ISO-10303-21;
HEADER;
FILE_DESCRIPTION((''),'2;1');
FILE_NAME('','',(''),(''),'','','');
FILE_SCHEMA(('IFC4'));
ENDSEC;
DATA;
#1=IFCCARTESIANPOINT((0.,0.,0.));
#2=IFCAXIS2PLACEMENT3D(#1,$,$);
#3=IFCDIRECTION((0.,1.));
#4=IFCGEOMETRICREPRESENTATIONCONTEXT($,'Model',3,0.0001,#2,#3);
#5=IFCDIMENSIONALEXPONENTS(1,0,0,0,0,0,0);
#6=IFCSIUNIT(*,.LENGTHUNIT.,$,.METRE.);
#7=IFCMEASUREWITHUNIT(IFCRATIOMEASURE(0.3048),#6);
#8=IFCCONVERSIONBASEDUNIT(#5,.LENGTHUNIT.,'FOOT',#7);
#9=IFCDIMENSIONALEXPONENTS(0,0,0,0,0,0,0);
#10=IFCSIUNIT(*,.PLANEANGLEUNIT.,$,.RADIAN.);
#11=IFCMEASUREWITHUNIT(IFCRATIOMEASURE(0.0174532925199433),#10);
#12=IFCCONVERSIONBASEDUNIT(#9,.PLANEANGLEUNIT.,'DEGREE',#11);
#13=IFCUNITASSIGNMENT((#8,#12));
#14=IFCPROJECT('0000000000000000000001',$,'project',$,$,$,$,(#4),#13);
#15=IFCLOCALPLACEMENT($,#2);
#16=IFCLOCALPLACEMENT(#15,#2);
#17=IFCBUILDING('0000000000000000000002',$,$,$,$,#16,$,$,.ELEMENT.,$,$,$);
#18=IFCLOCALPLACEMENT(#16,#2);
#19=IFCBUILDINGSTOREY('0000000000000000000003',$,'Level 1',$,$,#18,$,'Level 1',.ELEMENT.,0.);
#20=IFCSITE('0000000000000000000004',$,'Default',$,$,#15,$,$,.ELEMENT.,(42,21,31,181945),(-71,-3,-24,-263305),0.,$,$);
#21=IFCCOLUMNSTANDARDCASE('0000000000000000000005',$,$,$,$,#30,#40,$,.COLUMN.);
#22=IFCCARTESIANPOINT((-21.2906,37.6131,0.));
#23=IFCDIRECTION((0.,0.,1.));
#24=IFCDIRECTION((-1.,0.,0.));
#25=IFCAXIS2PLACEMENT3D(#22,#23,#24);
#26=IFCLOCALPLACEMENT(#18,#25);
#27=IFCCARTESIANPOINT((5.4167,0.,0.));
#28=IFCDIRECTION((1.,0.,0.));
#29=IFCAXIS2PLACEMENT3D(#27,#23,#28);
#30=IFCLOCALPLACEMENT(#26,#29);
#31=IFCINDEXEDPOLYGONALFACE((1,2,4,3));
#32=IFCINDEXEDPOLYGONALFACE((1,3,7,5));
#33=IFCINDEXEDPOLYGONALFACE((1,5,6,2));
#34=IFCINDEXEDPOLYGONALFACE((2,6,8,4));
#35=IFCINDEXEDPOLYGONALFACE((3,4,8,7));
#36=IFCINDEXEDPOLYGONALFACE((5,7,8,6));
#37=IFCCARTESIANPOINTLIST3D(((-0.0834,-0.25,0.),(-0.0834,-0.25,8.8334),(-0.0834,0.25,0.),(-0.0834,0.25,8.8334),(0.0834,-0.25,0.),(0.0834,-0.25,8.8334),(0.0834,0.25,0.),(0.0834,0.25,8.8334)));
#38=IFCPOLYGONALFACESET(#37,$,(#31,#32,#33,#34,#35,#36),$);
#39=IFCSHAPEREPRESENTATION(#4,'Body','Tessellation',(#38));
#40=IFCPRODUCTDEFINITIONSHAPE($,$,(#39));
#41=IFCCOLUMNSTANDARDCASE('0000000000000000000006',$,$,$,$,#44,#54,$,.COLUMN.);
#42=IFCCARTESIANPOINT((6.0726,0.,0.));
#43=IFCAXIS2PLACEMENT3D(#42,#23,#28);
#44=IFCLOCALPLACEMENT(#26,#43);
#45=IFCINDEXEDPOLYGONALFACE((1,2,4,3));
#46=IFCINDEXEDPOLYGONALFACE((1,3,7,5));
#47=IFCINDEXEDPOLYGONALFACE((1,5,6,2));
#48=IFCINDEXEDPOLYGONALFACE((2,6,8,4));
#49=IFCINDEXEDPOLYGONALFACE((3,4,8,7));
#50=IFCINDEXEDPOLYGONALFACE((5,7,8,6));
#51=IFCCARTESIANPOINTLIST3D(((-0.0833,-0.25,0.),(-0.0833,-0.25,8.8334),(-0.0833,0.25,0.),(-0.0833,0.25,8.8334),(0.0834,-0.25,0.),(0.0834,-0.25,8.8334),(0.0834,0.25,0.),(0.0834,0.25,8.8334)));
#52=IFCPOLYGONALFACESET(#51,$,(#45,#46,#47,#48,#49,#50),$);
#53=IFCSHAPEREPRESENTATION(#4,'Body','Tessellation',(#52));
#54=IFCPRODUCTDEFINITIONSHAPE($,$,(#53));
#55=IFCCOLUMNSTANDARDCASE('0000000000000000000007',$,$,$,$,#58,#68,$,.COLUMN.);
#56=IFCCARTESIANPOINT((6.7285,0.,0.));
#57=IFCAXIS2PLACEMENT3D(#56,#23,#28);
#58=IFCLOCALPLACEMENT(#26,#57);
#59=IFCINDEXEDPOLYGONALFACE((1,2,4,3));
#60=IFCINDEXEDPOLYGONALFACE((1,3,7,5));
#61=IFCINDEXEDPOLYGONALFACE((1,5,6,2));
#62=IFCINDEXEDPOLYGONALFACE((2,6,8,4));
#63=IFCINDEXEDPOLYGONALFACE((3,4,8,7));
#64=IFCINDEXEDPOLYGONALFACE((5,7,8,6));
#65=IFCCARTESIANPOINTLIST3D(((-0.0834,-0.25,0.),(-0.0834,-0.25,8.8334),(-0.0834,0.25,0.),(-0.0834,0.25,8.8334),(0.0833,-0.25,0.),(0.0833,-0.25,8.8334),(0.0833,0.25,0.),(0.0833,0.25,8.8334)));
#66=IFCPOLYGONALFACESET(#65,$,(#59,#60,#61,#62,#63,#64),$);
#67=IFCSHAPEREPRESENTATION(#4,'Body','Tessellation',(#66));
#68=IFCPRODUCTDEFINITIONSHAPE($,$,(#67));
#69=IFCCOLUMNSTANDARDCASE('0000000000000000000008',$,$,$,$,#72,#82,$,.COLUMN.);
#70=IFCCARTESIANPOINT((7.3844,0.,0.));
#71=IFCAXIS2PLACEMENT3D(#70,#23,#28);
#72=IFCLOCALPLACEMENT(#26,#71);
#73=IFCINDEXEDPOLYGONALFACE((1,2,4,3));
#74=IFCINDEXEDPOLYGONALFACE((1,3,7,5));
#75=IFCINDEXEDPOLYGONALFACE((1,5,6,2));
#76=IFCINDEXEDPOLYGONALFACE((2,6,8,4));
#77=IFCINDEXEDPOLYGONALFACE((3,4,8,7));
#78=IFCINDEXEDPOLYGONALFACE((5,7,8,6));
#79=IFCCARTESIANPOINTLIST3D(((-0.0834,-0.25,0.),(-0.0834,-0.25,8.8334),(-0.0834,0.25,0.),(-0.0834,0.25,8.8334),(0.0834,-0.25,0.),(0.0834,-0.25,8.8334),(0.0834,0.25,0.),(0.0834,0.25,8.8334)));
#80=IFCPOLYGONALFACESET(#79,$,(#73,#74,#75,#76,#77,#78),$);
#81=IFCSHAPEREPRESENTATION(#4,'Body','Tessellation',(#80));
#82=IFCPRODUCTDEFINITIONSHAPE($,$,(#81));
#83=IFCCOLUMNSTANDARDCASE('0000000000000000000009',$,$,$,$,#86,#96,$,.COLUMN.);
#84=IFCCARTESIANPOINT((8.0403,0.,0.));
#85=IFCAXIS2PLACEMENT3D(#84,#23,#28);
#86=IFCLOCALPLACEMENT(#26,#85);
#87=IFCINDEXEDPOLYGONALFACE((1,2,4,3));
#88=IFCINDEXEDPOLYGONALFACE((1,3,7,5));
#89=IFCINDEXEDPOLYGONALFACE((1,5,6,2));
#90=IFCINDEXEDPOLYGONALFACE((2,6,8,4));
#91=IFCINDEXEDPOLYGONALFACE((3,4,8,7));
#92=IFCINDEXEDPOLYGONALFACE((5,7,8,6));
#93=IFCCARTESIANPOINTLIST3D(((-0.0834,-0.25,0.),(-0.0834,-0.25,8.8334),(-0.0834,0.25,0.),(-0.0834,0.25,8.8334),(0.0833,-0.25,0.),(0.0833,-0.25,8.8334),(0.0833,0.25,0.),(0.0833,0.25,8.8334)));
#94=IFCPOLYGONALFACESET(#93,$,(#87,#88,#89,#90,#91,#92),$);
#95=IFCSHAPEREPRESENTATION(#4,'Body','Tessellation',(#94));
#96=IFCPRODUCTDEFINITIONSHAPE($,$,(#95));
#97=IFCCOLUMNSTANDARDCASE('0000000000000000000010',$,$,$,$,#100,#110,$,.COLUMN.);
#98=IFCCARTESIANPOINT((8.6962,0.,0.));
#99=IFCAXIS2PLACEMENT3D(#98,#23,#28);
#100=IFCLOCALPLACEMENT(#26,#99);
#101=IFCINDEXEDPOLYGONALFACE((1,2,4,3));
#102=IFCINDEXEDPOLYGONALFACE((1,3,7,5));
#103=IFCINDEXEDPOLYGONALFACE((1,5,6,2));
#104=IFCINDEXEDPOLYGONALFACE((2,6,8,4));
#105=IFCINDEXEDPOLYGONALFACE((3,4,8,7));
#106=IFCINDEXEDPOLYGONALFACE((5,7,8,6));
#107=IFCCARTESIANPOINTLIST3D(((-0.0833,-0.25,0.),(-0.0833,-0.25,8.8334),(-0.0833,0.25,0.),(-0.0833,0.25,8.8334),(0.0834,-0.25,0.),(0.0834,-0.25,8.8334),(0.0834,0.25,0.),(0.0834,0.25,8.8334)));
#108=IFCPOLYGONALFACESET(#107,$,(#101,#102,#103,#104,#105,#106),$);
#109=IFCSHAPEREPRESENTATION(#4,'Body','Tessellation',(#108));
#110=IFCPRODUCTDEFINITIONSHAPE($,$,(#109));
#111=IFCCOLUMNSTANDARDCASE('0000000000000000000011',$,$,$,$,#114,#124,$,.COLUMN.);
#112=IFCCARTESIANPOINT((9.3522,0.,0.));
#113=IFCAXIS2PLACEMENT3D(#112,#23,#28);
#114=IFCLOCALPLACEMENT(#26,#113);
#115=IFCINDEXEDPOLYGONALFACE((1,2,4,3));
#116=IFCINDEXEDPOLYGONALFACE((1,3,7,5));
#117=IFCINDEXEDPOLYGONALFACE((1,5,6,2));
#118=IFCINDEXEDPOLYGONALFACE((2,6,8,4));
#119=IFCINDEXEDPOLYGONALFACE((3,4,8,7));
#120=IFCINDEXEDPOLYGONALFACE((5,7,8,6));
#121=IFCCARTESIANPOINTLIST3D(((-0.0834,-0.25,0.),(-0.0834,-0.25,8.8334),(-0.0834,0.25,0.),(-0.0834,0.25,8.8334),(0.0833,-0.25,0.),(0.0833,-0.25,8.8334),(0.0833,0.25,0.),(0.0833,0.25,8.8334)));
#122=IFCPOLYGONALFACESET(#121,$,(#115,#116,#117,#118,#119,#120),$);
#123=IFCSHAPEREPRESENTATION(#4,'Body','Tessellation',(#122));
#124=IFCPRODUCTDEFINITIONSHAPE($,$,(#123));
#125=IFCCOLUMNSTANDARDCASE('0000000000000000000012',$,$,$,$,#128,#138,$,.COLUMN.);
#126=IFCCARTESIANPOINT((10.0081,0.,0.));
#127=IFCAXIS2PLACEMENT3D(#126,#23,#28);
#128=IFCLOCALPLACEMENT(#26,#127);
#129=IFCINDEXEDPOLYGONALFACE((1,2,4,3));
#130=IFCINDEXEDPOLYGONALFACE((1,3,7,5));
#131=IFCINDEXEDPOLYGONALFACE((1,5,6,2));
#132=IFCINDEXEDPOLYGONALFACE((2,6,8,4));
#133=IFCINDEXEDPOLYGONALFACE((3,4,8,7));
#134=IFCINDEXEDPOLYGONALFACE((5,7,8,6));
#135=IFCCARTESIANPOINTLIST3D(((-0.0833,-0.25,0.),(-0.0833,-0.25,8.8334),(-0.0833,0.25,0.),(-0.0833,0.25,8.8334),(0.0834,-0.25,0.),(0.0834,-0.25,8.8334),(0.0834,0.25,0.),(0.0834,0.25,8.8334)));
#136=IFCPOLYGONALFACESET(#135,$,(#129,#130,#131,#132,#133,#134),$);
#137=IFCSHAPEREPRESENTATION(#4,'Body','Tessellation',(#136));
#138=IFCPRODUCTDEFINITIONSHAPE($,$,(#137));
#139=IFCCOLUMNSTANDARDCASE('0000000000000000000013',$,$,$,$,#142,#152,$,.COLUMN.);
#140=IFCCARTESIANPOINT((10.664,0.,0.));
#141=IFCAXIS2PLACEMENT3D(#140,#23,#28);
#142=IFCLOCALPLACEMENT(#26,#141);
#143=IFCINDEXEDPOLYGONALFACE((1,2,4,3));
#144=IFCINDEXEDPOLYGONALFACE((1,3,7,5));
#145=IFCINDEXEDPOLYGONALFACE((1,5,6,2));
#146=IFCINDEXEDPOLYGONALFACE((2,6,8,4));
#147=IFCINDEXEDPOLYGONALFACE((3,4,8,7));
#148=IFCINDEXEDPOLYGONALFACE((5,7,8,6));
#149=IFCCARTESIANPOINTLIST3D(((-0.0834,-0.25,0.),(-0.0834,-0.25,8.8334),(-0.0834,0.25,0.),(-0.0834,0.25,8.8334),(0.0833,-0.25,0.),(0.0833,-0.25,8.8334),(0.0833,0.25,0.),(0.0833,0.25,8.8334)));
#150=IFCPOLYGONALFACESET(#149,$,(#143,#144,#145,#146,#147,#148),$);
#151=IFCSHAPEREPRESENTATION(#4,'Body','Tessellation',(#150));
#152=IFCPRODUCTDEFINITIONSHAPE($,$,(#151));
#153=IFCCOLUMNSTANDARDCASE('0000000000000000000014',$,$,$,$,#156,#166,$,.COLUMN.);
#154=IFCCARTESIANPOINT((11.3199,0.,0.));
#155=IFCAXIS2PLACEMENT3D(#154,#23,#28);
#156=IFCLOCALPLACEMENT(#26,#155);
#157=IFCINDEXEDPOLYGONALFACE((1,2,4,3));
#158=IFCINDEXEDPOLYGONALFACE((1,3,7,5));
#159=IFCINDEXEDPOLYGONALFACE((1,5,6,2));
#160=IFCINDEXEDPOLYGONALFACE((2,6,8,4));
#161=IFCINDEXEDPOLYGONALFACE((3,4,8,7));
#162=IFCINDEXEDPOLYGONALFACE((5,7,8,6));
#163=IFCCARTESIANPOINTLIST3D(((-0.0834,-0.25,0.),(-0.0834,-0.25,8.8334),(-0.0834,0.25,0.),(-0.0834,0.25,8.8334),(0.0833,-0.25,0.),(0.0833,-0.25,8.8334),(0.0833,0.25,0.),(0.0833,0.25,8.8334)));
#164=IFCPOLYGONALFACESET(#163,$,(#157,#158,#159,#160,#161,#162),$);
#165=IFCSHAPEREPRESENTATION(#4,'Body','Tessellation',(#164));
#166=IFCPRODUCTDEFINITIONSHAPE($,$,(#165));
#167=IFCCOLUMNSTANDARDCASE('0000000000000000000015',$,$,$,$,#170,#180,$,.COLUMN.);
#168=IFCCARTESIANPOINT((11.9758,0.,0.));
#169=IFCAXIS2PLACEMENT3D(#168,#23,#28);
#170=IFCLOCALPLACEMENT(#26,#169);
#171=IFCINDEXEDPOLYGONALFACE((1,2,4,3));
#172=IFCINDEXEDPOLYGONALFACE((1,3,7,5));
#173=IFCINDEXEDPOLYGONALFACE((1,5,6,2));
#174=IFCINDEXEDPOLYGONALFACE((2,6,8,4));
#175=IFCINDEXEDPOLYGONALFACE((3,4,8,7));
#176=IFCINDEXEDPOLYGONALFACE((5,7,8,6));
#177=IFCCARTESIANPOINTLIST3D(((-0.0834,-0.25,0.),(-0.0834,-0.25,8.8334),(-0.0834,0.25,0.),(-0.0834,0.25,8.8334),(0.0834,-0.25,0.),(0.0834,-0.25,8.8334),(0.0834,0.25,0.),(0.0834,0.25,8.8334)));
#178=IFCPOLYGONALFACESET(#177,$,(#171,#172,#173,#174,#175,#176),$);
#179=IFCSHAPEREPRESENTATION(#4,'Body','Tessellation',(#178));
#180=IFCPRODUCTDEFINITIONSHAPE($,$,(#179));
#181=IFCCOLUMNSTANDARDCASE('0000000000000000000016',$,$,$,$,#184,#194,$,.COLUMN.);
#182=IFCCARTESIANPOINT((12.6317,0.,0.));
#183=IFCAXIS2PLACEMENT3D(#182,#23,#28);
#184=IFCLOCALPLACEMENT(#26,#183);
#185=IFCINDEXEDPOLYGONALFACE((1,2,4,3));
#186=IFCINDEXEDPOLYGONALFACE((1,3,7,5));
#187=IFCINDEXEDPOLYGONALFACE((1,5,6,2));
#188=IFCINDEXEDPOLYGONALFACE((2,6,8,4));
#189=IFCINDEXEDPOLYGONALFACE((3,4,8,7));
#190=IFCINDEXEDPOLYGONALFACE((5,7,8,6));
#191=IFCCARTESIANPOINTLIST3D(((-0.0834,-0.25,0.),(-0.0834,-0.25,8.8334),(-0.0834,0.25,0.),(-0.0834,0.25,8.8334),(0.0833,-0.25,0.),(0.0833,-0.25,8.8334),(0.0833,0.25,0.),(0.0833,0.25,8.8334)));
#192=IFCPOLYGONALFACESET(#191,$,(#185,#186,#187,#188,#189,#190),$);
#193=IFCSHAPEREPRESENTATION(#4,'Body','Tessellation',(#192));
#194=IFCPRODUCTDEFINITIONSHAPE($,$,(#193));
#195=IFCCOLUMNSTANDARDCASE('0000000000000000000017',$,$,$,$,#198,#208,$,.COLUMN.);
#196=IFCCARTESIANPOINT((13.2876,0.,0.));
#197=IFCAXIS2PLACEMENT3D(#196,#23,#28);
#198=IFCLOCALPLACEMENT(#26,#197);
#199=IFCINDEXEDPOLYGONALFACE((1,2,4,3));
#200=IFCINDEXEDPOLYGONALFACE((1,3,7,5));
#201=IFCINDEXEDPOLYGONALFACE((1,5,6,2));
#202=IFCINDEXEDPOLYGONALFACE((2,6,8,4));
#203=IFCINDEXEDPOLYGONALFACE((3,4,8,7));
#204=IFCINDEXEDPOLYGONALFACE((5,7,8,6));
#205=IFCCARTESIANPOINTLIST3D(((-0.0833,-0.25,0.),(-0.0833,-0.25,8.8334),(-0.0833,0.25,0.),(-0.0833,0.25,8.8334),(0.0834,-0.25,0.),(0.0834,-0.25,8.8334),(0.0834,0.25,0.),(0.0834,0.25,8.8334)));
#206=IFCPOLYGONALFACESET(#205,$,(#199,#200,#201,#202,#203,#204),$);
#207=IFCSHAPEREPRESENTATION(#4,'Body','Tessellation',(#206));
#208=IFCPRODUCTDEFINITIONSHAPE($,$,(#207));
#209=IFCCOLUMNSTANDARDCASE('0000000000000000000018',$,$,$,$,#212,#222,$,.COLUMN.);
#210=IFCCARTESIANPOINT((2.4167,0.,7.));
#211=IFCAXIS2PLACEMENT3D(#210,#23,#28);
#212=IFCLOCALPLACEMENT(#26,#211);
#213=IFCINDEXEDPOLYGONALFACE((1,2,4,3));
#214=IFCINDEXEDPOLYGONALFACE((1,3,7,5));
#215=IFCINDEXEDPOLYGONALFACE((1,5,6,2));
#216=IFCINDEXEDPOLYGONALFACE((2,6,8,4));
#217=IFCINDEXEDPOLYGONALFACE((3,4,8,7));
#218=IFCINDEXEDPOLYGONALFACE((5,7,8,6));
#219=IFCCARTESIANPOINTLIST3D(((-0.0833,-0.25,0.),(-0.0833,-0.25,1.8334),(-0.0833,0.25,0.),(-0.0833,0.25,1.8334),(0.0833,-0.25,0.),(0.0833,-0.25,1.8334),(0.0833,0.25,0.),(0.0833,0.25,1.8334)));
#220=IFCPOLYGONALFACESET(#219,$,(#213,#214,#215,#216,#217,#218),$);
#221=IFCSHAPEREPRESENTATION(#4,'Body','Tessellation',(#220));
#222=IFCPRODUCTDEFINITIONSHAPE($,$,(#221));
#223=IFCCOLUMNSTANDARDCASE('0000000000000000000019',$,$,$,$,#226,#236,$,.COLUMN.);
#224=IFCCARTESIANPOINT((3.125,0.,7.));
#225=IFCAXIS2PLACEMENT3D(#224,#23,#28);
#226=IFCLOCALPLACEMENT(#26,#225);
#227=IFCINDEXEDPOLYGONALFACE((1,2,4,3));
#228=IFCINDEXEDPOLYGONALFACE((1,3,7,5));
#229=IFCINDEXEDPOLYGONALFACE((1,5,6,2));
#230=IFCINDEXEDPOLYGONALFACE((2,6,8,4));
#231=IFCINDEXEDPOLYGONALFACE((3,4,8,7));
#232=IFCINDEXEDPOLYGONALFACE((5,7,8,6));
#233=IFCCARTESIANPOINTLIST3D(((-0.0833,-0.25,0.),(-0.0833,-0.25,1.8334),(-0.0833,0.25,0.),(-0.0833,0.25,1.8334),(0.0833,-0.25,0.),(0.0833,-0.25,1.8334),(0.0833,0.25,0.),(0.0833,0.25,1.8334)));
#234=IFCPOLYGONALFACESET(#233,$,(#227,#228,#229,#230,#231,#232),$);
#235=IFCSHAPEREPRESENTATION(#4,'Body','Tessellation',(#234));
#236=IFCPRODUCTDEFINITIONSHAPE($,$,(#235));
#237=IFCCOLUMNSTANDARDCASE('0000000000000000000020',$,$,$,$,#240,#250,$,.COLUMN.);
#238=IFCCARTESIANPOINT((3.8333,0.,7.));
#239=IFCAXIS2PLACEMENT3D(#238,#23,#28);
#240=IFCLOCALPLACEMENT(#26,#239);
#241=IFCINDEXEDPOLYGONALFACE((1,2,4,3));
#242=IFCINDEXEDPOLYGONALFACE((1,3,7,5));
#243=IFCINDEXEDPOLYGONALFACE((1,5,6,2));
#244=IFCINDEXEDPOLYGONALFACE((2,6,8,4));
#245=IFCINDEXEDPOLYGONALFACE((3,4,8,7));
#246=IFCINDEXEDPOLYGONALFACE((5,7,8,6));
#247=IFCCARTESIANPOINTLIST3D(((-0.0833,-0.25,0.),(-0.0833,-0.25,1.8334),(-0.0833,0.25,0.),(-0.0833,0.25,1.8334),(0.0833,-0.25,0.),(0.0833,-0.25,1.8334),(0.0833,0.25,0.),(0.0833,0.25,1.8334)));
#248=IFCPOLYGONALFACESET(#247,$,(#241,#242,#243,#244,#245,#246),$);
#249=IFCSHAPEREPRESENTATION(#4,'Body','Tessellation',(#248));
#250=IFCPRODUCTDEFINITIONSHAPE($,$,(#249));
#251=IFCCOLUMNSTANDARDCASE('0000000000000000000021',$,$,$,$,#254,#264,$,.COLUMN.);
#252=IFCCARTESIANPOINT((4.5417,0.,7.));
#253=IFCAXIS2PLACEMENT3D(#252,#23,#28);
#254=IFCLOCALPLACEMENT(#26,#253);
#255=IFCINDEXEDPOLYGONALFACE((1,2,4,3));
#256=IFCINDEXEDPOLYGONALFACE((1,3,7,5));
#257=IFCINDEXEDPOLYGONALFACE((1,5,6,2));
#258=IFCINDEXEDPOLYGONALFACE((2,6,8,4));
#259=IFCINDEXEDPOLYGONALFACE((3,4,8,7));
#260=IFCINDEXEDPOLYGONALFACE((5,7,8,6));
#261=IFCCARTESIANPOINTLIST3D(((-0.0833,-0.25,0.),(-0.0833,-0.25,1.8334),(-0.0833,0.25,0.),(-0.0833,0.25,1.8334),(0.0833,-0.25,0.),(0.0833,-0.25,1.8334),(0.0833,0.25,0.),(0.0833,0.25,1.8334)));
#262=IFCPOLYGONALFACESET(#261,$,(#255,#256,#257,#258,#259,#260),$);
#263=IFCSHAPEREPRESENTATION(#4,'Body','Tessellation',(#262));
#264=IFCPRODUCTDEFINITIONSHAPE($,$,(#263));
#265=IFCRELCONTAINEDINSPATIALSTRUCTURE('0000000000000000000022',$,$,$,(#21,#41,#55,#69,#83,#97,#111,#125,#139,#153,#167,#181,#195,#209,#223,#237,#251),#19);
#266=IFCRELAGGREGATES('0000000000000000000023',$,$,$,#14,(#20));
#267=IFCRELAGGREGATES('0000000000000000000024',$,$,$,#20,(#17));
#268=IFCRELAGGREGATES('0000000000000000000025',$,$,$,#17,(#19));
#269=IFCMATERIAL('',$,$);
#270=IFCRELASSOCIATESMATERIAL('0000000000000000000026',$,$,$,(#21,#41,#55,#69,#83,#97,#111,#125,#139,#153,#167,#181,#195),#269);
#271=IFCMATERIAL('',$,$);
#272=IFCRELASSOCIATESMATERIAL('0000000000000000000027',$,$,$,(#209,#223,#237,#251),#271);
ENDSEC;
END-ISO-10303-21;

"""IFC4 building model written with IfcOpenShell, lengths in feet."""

from ifc_helpers import new_model, entity, si_unit, converted_unit, direction, frame, origin, place, context, project, spatial, rectangle, extrude, material, element, save


model = new_model("IFC4")

# Units and contexts
model_context = context("Model", 3, precision=0.0001, world=origin(), true_north=direction((0.0, 1.0)))
ifc_project = project(units=[converted_unit("LENGTHUNIT", "FOOT", entity("IfcRatioMeasure", 0.3048), si_unit("LENGTHUNIT", "METRE"), dimensions=[1, 0, 0, 0, 0, 0, 0]), converted_unit("PLANEANGLEUNIT", "DEGREE", entity("IfcRatioMeasure", 0.0174532925199433), si_unit("PLANEANGLEUNIT", "RADIAN"), dimensions=[0, 0, 0, 0, 0, 0, 0])], contexts=[model_context])

# Site, building, storey
site_placement = place(None, origin())
site = spatial("IfcSite", under=ifc_project, at=site_placement, Name="Default", CompositionType="ELEMENT", RefLatitude=(42, 21, 31, 181945), RefLongitude=(-71, -3, -24, -263305), RefElevation=0.0)
building_placement = place(site_placement, origin())
building = spatial("IfcBuilding", under=site, at=building_placement, CompositionType="ELEMENT")
storey_placement = place(building_placement, origin())
storey = spatial("IfcBuildingStorey", under=building, at=storey_placement, Name="Level 1", LongName="Level 1", CompositionType="ELEMENT", Elevation=0.0)

# Columns
ifc_material_1 = material(Name="")
placement_1 = place(storey_placement, frame((-21.2906, 37.6131, 0.0), z_axis=(0.0, 0.0, 1.0), x_axis=(-1.0, 0.0, 0.0)))
for number, where, z_axis, x_axis in (
    (1, (5.4167, 0.0, 0.0), (0.0, 0.0, 1.0), (1.0, 0.0, 0.0)),
    (2, (6.0726, 0.0, 0.0), (0.0, 0.0, 1.0), (1.0, 0.0, 0.0)),
    (3, (6.7285, 0.0, 0.0), (0.0, 0.0, 1.0), (1.0, 0.0, 0.0)),
    (4, (7.3844, 0.0, 0.0), (0.0, 0.0, 1.0), (1.0, 0.0, 0.0)),
    (5, (8.0403, 0.0, 0.0), (0.0, 0.0, 1.0), (1.0, 0.0, 0.0)),
    (6, (8.6962, 0.0, 0.0), (0.0, 0.0, 1.0), (1.0, 0.0, 0.0)),
    (7, (9.3522, 0.0, 0.0), (0.0, 0.0, 1.0), (1.0, 0.0, 0.0)),
    (8, (10.0081, 0.0, 0.0), (0.0, 0.0, 1.0), (1.0, 0.0, 0.0)),
    (9, (10.664, 0.0, 0.0), (0.0, 0.0, 1.0), (1.0, 0.0, 0.0)),
    (10, (11.3199, 0.0, 0.0), (0.0, 0.0, 1.0), (1.0, 0.0, 0.0)),
    (11, (11.9758, 0.0, 0.0), (0.0, 0.0, 1.0), (1.0, 0.0, 0.0)),
    (12, (12.6317, 0.0, 0.0), (0.0, 0.0, 1.0), (1.0, 0.0, 0.0)),
    (13, (13.2876, 0.0, 0.0), (0.0, 0.0, 1.0), (1.0, 0.0, 0.0)),
):
    element("IfcColumnStandardCase", number, at=place(placement_1, frame(where, z_axis=z_axis, x_axis=x_axis)), inside=storey, material=ifc_material_1, PredefinedType="COLUMN", context=model_context, shape_type="SweptSolid", body=[
        extrude(rectangle(XDim=0.1667, YDim=0.5), origin(), (0.0, 0.0, 1.0), 8.8334),
    ])
ifc_material_2 = material(Name="")
for number, where, z_axis, x_axis in (
    (14, (2.4167, 0.0, 7.0), (0.0, 0.0, 1.0), (1.0, 0.0, 0.0)),
    (15, (3.125, 0.0, 7.0), (0.0, 0.0, 1.0), (1.0, 0.0, 0.0)),
    (16, (3.8333, 0.0, 7.0), (0.0, 0.0, 1.0), (1.0, 0.0, 0.0)),
    (17, (4.5417, 0.0, 7.0), (0.0, 0.0, 1.0), (1.0, 0.0, 0.0)),
):
    element("IfcColumnStandardCase", number, at=place(placement_1, frame(where, z_axis=z_axis, x_axis=x_axis)), inside=storey, material=ifc_material_2, PredefinedType="COLUMN", context=model_context, shape_type="SweptSolid", body=[
        extrude(rectangle(XDim=0.1667, YDim=0.5), origin(), (0.0, 0.0, 1.0), 1.8334),
    ])

save(model, "model.ifc")
